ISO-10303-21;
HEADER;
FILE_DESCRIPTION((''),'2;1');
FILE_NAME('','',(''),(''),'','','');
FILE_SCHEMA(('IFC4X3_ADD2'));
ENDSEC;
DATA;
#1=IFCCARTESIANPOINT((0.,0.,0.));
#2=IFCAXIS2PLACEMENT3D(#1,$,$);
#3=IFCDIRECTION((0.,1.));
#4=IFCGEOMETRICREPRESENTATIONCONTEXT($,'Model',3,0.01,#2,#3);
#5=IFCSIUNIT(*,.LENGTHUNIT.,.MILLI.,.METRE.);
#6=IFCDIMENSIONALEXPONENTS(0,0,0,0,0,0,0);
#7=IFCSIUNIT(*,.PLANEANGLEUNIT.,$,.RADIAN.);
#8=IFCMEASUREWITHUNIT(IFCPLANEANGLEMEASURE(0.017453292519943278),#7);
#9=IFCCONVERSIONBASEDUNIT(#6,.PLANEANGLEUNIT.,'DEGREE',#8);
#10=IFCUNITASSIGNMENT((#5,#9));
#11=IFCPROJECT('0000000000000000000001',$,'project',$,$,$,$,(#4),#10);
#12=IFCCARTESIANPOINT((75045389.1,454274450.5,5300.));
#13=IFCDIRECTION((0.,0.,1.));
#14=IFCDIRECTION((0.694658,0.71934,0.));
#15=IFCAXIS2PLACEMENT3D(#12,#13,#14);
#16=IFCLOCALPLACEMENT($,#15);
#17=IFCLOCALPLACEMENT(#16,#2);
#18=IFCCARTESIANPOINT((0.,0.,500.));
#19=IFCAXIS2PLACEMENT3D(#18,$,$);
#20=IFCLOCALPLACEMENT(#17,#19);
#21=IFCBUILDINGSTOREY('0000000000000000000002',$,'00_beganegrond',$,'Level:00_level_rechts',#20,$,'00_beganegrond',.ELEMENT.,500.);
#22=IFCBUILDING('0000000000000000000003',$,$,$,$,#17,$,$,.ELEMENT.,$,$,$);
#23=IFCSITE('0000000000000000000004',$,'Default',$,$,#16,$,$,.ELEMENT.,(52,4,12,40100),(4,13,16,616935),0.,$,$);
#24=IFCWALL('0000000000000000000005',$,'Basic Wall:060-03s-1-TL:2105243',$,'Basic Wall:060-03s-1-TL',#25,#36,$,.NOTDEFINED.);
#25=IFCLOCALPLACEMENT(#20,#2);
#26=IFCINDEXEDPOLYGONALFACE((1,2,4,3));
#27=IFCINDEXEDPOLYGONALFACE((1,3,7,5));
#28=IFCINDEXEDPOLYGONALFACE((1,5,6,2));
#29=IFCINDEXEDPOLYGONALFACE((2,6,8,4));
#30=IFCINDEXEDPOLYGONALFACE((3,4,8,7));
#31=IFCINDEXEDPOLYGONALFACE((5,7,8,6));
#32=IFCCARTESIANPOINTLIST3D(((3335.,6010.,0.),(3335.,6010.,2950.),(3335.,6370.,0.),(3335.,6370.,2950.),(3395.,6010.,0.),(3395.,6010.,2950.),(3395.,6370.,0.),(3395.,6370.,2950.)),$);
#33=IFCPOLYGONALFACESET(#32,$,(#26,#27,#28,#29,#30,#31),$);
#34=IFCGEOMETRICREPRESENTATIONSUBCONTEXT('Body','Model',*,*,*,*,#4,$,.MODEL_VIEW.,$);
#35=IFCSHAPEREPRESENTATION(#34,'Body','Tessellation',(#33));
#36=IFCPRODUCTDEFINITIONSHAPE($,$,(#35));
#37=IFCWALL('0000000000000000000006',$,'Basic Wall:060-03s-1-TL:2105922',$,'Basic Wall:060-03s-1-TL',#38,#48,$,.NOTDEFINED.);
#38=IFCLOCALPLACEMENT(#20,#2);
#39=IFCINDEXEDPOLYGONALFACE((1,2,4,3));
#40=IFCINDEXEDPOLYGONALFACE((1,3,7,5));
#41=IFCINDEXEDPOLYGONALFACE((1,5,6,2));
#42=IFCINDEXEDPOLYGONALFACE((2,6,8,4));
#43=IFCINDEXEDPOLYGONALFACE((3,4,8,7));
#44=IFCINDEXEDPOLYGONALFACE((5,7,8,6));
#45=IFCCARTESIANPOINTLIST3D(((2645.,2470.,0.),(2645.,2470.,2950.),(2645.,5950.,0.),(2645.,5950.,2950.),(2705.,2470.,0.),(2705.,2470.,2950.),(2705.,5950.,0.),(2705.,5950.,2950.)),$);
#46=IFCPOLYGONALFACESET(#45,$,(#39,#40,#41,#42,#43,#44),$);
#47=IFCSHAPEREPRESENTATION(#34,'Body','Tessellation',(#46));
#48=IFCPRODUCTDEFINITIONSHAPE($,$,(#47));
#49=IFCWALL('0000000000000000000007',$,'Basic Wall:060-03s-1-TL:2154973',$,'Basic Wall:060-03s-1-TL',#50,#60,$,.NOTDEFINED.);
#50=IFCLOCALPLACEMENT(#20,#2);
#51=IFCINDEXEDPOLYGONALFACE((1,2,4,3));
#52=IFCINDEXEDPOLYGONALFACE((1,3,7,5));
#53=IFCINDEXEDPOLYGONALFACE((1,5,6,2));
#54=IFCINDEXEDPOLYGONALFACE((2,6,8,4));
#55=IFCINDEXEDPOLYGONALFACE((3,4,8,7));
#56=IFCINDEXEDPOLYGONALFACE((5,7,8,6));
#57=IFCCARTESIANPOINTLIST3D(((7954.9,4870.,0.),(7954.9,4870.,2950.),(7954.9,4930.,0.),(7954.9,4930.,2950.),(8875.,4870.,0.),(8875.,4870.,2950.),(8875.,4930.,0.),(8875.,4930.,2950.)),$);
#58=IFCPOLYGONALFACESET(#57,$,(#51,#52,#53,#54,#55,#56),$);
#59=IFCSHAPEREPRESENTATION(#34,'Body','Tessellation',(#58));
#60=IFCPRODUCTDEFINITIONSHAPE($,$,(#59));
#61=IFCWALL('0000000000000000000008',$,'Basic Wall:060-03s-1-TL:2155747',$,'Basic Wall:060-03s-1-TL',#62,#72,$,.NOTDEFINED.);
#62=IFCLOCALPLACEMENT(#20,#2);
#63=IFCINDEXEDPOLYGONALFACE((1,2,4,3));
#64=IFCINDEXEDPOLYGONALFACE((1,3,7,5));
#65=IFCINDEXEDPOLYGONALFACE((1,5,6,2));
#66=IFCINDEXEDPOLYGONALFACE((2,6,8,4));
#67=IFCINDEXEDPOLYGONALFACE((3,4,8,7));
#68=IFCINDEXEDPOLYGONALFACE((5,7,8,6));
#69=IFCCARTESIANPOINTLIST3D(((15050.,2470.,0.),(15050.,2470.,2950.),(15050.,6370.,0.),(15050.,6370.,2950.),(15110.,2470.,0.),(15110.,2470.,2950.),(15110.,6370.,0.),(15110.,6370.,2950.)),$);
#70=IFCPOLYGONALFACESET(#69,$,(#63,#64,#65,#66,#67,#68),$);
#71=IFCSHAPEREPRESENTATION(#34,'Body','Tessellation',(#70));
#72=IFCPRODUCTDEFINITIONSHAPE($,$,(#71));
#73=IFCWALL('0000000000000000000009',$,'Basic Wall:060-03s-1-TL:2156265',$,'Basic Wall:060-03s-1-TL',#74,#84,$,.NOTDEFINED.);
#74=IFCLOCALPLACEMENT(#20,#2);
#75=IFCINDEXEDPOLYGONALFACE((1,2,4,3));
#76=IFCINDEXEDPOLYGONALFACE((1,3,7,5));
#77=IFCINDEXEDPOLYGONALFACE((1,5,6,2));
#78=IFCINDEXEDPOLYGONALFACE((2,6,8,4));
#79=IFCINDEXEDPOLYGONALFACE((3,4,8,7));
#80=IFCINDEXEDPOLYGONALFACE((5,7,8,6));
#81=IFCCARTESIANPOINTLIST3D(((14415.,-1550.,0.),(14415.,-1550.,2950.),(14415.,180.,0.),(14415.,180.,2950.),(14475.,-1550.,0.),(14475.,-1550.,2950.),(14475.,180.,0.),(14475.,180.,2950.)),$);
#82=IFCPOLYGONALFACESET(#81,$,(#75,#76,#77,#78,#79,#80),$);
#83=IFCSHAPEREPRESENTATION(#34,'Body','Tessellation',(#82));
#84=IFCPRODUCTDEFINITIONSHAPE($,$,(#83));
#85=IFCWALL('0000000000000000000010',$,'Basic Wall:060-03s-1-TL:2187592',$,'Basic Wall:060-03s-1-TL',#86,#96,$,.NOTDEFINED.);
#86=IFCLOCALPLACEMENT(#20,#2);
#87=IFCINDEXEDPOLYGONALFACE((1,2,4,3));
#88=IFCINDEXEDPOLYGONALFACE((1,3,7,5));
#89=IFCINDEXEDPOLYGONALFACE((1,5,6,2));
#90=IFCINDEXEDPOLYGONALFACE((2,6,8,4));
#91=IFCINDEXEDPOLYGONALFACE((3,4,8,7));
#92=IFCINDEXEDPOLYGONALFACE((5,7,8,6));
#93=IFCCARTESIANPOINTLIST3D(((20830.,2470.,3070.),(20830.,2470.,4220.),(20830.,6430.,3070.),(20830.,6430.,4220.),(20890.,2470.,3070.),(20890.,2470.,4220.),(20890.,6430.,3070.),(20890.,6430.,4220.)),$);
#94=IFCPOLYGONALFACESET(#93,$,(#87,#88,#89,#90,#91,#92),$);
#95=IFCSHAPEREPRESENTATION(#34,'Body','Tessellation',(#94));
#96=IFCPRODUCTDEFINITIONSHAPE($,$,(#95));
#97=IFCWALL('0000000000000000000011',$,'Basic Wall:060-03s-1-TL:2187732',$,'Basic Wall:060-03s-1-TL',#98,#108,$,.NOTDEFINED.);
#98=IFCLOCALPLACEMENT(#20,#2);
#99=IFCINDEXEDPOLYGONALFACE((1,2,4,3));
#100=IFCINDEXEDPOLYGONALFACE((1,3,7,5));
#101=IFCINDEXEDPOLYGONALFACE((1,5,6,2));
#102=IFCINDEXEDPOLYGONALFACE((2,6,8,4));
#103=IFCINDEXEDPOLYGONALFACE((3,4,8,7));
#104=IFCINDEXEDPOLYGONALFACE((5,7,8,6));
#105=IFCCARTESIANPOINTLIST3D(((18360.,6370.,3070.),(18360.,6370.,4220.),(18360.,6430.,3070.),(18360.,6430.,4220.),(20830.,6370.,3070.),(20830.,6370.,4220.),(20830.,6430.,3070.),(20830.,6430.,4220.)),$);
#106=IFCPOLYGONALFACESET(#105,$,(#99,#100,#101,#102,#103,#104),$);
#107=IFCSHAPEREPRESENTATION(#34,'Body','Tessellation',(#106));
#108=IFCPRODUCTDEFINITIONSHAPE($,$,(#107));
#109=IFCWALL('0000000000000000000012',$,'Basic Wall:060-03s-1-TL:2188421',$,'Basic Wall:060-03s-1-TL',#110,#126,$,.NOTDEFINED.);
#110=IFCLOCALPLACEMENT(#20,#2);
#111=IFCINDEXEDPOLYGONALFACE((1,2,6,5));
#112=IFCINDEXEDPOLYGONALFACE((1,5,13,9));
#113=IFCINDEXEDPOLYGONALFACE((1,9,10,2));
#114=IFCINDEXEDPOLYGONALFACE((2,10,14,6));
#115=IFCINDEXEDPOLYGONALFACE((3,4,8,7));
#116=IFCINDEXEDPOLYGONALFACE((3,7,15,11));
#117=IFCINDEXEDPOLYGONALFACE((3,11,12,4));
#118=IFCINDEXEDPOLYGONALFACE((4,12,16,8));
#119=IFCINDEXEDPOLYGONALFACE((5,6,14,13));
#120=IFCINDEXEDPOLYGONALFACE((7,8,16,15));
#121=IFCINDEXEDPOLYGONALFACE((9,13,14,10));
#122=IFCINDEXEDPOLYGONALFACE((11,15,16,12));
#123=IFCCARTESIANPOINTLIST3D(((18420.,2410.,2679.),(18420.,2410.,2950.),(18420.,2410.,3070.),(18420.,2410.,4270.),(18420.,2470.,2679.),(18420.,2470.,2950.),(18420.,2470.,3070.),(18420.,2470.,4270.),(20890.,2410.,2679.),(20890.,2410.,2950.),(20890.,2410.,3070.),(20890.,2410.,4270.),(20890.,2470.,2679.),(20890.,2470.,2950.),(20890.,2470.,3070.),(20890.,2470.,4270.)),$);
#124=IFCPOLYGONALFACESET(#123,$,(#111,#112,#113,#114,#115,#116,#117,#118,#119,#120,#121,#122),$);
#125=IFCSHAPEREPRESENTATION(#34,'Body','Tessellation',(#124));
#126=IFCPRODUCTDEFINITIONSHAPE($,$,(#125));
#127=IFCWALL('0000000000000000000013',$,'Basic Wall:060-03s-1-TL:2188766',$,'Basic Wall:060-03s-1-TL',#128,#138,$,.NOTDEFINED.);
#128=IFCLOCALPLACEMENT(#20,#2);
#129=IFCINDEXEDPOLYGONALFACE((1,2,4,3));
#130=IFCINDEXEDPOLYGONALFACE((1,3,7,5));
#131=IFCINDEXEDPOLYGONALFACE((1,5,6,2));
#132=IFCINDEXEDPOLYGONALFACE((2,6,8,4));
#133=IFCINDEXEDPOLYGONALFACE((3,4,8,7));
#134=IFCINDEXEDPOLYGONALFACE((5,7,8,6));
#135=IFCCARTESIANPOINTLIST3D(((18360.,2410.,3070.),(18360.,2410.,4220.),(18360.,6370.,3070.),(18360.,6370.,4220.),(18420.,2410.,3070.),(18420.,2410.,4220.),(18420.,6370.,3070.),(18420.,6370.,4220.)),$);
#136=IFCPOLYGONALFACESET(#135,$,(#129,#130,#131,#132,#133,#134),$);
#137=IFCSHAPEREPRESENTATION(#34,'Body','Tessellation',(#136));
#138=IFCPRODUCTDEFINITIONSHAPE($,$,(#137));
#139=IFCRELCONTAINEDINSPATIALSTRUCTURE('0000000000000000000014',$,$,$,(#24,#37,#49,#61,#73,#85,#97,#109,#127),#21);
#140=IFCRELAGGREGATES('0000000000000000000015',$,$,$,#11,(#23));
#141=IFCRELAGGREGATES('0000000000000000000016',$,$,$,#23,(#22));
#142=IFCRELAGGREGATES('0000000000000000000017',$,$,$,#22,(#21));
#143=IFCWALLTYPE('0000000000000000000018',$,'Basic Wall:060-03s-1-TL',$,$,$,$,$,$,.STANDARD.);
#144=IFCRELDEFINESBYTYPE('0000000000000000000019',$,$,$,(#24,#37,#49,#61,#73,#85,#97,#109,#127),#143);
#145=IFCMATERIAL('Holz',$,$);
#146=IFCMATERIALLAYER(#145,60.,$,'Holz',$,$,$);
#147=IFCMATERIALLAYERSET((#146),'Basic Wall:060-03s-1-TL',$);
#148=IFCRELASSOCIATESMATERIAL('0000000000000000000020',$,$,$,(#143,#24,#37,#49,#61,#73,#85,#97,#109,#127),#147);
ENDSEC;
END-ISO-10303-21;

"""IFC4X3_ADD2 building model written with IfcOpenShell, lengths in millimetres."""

from ifc_helpers import new_model, entity, si_unit, converted_unit, direction, frame, frame_2d, origin, place, context, subcontext, project, spatial, polyline, rectangle, extrude, clip, bounded_halfspace, material, layer, layer_set, type_object, element, save


model = new_model("IFC4X3_ADD2")

# Units and contexts
model_context = context("Model", 3, precision=0.01, world=origin(), true_north=direction((0.0, 1.0)))
body_context = subcontext(model_context, "Body", "Model", "MODEL_VIEW")
ifc_project = project(units=[si_unit("LENGTHUNIT", "METRE", prefix="MILLI"), converted_unit("PLANEANGLEUNIT", "DEGREE", entity("IfcPlaneAngleMeasure", 0.017453292519943278), si_unit("PLANEANGLEUNIT", "RADIAN"), dimensions=[0, 0, 0, 0, 0, 0, 0])], contexts=[model_context])

# Site, building, storey
site_placement = place(None, frame((75045389.1, 454274450.5, 5300.0), z_axis=(0.0, 0.0, 1.0), x_axis=(0.694658, 0.71934, 0.0)))
site = spatial("IfcSite", under=ifc_project, at=site_placement, Name="Default", CompositionType="ELEMENT", RefLatitude=(52, 4, 12, 40100), RefLongitude=(4, 13, 16, 616935), RefElevation=0.0)
building_placement = place(site_placement, origin())
building = spatial("IfcBuilding", under=site, at=building_placement, CompositionType="ELEMENT")
storey_placement = place(building_placement, frame((0.0, 0.0, 500.0)))
storey = spatial("IfcBuildingStorey", under=building, at=storey_placement, Name="00_beganegrond", ObjectType="Level:00_level_rechts", LongName="00_beganegrond", CompositionType="ELEMENT", Elevation=500.0)

# Walls
ifc_material_1 = material(Name="Holz")
ifc_layer = layer(ifc_material_1, 60.0, Name="Holz")
ifc_layer_set = layer_set([ifc_layer], Name="Basic Wall:060-03s-1-TL")
wall_type = type_object("IfcWallType", Name="Basic Wall:060-03s-1-TL", PredefinedType="STANDARD", material=ifc_layer_set)
wall_1_placement = place(storey_placement, frame((3365.0, 6010.0, 0.0), z_axis=(0.0, 0.0, 1.0), x_axis=(0.0, 1.0, 0.0)))
element("IfcWall", 1, at=wall_1_placement, inside=storey, type_object=wall_type, material=ifc_layer_set, Name="Basic Wall:060-03s-1-TL:2105243", ObjectType="Basic Wall:060-03s-1-TL", PredefinedType="NOTDEFINED", context=body_context, shape_type="SweptSolid", body=[
    extrude(rectangle(XDim=360.0, YDim=60.0, at=frame_2d((180.0, 0.0), x_axis=(-1.0, 0.0))), origin(), (0.0, 0.0, 1.0), 2950.0),
])
wall_2_placement = place(storey_placement, frame((2675.0, 5950.0, 0.0), z_axis=(0.0, 0.0, 1.0), x_axis=(0.0, -1.0, 0.0)))
element("IfcWall", 2, at=wall_2_placement, inside=storey, type_object=wall_type, material=ifc_layer_set, Name="Basic Wall:060-03s-1-TL:2105922", ObjectType="Basic Wall:060-03s-1-TL", PredefinedType="NOTDEFINED", context=body_context, shape_type="SweptSolid", body=[
    extrude(rectangle(XDim=3480.0, YDim=60.0, at=frame_2d((1740.0, 0.0), x_axis=(-1.0, 0.0))), origin(), (0.0, 0.0, 1.0), 2950.0),
])
wall_3_placement = place(storey_placement, frame((7954.9, 4900.0, 0.0)))
element("IfcWall", 3, at=wall_3_placement, inside=storey, type_object=wall_type, material=ifc_layer_set, Name="Basic Wall:060-03s-1-TL:2154973", ObjectType="Basic Wall:060-03s-1-TL", PredefinedType="NOTDEFINED", context=body_context, shape_type="SweptSolid", body=[
    extrude(rectangle(XDim=920.1, YDim=60.0, at=frame_2d((460.1, 0.0), x_axis=(-1.0, 0.0))), origin(), (0.0, 0.0, 1.0), 2950.0),
])
wall_4_placement = place(storey_placement, frame((15080.0, 6370.0, 0.0), z_axis=(0.0, 0.0, 1.0), x_axis=(0.0, -1.0, 0.0)))
element("IfcWall", 4, at=wall_4_placement, inside=storey, type_object=wall_type, material=ifc_layer_set, Name="Basic Wall:060-03s-1-TL:2155747", ObjectType="Basic Wall:060-03s-1-TL", PredefinedType="NOTDEFINED", context=body_context, shape_type="SweptSolid", body=[
    extrude(rectangle(XDim=3900.0, YDim=60.0, at=frame_2d((1950.0, 0.0), x_axis=(-1.0, 0.0))), origin(), (0.0, 0.0, 1.0), 2950.0),
])
wall_5_placement = place(storey_placement, frame((14445.0, 180.0, 0.0), z_axis=(0.0, 0.0, 1.0), x_axis=(0.0, -1.0, 0.0)))
element("IfcWall", 5, at=wall_5_placement, inside=storey, type_object=wall_type, material=ifc_layer_set, Name="Basic Wall:060-03s-1-TL:2156265", ObjectType="Basic Wall:060-03s-1-TL", PredefinedType="NOTDEFINED", context=body_context, shape_type="SweptSolid", body=[
    extrude(rectangle(XDim=1730.0, YDim=60.0, at=frame_2d((865.0, 0.0), x_axis=(-1.0, 0.0))), origin(), (0.0, 0.0, 1.0), 2950.0),
])
wall_6_placement = place(storey_placement, frame((20860.0, 2470.0, 3070.0), z_axis=(0.0, 0.0, 1.0), x_axis=(0.0, 1.0, 0.0)))
element("IfcWall", 6, at=wall_6_placement, inside=storey, type_object=wall_type, material=ifc_layer_set, Name="Basic Wall:060-03s-1-TL:2187592", ObjectType="Basic Wall:060-03s-1-TL", PredefinedType="NOTDEFINED", context=body_context, shape_type="Clipping", body=[
    clip(extrude(rectangle(XDim=3960.0, YDim=60.0, at=frame_2d((1980.0, 0.0), x_axis=(-1.0, 0.0))), origin(), (0.0, 0.0, 1.0), 1150.0), bounded_halfspace(frame((3960.0, -30.0, 0.0), z_axis=(0.0, 0.0, 1.0), x_axis=(0.211145, 0.977455, 0.0)), True, frame((3960.0, -30.0, 0.0)), polyline([(0.0, 0.0), (0.0, 60.0), (-60.0, 60.0), (-3960.0, 60.0), (-3960.0, 0.0), (0.0, 0.0)]))),
])
wall_7_placement = place(storey_placement, frame((20830.0, 6400.0, 3070.0), z_axis=(0.0, 0.0, 1.0), x_axis=(-1.0, 0.0, 0.0)))
element("IfcWall", 7, at=wall_7_placement, inside=storey, type_object=wall_type, material=ifc_layer_set, Name="Basic Wall:060-03s-1-TL:2187732", ObjectType="Basic Wall:060-03s-1-TL", PredefinedType="NOTDEFINED", context=body_context, shape_type="Clipping", body=[
    clip(extrude(rectangle(XDim=2470.0, YDim=60.0, at=frame_2d((1235.0, 0.0), x_axis=(-1.0, 0.0))), origin(), (0.0, 0.0, 1.0), 1150.0), bounded_halfspace(frame((2470.0, -30.0, 0.0), z_axis=(0.0, 0.0, 1.0), x_axis=(0.977455, -0.211145, 0.0)), True, frame((2470.0, -30.0, 0.0)), polyline([(0.0, 0.0), (0.0, 60.0), (-60.0, 60.0), (-2470.0, 60.0), (-2470.0, 0.0), (0.0, 0.0)]))),
])

# Wall, opening
wall_8_placement = place(storey_placement, frame((20890.0, 2440.0, 2679.0), z_axis=(0.0, 0.0, 1.0), x_axis=(-1.0, 0.0, 0.0)))
wall_8 = element("IfcWall", 8, at=wall_8_placement, inside=storey, type_object=wall_type, material=ifc_layer_set, Name="Basic Wall:060-03s-1-TL:2188421", ObjectType="Basic Wall:060-03s-1-TL", PredefinedType="NOTDEFINED", context=body_context, shape_type="SweptSolid", body=[
    extrude(rectangle(XDim=2470.0, YDim=60.0, at=frame_2d((1235.0, 0.0), x_axis=(-1.0, 0.0))), origin(), (0.0, 0.0, 1.0), 1591.0),
])
opening_placement = place(storey_placement, frame((20890.0, 2440.0, 2679.0), z_axis=(0.0, 0.0, 1.0), x_axis=(-1.0, 0.0, 0.0)))
element("IfcOpeningElement", 9, at=opening_placement, cuts=wall_8, PredefinedType="OPENING", context=body_context, shape_type="SweptSolid", body=[
    extrude(rectangle(XDim=2470.0, YDim=60.0, at=frame_2d((235.0, 6.0), x_axis=(1.0, 0.0))), frame((1000.0, -6.0, 271.0)), (0.0, 0.0, 1.0), 120.0),
])

# Wall
wall_9_placement = place(storey_placement, frame((18390.0, 2410.0, 3070.0), z_axis=(0.0, 0.0, 1.0), x_axis=(0.0, 1.0, 0.0)))
element("IfcWall", 10, at=wall_9_placement, inside=storey, type_object=wall_type, material=ifc_layer_set, Name="Basic Wall:060-03s-1-TL:2188766", ObjectType="Basic Wall:060-03s-1-TL", PredefinedType="NOTDEFINED", context=body_context, shape_type="Clipping", body=[
    clip(extrude(rectangle(XDim=3960.0, YDim=60.0, at=frame_2d((1980.0, 0.0), x_axis=(-1.0, 0.0))), origin(), (0.0, 0.0, 1.0), 1150.0), bounded_halfspace(frame((3960.0, -30.0, 0.0), z_axis=(0.0, 0.0, 1.0), x_axis=(0.211145, 0.977455, 0.0)), True, frame((3960.0, -30.0, 0.0)), polyline([(0.0, 0.0), (0.0, 60.0), (-3960.0, 60.0), (-3960.0, 0.0), (-3900.0, 0.0), (0.0, 0.0)]))),
])

save(model, "model.ifc")
